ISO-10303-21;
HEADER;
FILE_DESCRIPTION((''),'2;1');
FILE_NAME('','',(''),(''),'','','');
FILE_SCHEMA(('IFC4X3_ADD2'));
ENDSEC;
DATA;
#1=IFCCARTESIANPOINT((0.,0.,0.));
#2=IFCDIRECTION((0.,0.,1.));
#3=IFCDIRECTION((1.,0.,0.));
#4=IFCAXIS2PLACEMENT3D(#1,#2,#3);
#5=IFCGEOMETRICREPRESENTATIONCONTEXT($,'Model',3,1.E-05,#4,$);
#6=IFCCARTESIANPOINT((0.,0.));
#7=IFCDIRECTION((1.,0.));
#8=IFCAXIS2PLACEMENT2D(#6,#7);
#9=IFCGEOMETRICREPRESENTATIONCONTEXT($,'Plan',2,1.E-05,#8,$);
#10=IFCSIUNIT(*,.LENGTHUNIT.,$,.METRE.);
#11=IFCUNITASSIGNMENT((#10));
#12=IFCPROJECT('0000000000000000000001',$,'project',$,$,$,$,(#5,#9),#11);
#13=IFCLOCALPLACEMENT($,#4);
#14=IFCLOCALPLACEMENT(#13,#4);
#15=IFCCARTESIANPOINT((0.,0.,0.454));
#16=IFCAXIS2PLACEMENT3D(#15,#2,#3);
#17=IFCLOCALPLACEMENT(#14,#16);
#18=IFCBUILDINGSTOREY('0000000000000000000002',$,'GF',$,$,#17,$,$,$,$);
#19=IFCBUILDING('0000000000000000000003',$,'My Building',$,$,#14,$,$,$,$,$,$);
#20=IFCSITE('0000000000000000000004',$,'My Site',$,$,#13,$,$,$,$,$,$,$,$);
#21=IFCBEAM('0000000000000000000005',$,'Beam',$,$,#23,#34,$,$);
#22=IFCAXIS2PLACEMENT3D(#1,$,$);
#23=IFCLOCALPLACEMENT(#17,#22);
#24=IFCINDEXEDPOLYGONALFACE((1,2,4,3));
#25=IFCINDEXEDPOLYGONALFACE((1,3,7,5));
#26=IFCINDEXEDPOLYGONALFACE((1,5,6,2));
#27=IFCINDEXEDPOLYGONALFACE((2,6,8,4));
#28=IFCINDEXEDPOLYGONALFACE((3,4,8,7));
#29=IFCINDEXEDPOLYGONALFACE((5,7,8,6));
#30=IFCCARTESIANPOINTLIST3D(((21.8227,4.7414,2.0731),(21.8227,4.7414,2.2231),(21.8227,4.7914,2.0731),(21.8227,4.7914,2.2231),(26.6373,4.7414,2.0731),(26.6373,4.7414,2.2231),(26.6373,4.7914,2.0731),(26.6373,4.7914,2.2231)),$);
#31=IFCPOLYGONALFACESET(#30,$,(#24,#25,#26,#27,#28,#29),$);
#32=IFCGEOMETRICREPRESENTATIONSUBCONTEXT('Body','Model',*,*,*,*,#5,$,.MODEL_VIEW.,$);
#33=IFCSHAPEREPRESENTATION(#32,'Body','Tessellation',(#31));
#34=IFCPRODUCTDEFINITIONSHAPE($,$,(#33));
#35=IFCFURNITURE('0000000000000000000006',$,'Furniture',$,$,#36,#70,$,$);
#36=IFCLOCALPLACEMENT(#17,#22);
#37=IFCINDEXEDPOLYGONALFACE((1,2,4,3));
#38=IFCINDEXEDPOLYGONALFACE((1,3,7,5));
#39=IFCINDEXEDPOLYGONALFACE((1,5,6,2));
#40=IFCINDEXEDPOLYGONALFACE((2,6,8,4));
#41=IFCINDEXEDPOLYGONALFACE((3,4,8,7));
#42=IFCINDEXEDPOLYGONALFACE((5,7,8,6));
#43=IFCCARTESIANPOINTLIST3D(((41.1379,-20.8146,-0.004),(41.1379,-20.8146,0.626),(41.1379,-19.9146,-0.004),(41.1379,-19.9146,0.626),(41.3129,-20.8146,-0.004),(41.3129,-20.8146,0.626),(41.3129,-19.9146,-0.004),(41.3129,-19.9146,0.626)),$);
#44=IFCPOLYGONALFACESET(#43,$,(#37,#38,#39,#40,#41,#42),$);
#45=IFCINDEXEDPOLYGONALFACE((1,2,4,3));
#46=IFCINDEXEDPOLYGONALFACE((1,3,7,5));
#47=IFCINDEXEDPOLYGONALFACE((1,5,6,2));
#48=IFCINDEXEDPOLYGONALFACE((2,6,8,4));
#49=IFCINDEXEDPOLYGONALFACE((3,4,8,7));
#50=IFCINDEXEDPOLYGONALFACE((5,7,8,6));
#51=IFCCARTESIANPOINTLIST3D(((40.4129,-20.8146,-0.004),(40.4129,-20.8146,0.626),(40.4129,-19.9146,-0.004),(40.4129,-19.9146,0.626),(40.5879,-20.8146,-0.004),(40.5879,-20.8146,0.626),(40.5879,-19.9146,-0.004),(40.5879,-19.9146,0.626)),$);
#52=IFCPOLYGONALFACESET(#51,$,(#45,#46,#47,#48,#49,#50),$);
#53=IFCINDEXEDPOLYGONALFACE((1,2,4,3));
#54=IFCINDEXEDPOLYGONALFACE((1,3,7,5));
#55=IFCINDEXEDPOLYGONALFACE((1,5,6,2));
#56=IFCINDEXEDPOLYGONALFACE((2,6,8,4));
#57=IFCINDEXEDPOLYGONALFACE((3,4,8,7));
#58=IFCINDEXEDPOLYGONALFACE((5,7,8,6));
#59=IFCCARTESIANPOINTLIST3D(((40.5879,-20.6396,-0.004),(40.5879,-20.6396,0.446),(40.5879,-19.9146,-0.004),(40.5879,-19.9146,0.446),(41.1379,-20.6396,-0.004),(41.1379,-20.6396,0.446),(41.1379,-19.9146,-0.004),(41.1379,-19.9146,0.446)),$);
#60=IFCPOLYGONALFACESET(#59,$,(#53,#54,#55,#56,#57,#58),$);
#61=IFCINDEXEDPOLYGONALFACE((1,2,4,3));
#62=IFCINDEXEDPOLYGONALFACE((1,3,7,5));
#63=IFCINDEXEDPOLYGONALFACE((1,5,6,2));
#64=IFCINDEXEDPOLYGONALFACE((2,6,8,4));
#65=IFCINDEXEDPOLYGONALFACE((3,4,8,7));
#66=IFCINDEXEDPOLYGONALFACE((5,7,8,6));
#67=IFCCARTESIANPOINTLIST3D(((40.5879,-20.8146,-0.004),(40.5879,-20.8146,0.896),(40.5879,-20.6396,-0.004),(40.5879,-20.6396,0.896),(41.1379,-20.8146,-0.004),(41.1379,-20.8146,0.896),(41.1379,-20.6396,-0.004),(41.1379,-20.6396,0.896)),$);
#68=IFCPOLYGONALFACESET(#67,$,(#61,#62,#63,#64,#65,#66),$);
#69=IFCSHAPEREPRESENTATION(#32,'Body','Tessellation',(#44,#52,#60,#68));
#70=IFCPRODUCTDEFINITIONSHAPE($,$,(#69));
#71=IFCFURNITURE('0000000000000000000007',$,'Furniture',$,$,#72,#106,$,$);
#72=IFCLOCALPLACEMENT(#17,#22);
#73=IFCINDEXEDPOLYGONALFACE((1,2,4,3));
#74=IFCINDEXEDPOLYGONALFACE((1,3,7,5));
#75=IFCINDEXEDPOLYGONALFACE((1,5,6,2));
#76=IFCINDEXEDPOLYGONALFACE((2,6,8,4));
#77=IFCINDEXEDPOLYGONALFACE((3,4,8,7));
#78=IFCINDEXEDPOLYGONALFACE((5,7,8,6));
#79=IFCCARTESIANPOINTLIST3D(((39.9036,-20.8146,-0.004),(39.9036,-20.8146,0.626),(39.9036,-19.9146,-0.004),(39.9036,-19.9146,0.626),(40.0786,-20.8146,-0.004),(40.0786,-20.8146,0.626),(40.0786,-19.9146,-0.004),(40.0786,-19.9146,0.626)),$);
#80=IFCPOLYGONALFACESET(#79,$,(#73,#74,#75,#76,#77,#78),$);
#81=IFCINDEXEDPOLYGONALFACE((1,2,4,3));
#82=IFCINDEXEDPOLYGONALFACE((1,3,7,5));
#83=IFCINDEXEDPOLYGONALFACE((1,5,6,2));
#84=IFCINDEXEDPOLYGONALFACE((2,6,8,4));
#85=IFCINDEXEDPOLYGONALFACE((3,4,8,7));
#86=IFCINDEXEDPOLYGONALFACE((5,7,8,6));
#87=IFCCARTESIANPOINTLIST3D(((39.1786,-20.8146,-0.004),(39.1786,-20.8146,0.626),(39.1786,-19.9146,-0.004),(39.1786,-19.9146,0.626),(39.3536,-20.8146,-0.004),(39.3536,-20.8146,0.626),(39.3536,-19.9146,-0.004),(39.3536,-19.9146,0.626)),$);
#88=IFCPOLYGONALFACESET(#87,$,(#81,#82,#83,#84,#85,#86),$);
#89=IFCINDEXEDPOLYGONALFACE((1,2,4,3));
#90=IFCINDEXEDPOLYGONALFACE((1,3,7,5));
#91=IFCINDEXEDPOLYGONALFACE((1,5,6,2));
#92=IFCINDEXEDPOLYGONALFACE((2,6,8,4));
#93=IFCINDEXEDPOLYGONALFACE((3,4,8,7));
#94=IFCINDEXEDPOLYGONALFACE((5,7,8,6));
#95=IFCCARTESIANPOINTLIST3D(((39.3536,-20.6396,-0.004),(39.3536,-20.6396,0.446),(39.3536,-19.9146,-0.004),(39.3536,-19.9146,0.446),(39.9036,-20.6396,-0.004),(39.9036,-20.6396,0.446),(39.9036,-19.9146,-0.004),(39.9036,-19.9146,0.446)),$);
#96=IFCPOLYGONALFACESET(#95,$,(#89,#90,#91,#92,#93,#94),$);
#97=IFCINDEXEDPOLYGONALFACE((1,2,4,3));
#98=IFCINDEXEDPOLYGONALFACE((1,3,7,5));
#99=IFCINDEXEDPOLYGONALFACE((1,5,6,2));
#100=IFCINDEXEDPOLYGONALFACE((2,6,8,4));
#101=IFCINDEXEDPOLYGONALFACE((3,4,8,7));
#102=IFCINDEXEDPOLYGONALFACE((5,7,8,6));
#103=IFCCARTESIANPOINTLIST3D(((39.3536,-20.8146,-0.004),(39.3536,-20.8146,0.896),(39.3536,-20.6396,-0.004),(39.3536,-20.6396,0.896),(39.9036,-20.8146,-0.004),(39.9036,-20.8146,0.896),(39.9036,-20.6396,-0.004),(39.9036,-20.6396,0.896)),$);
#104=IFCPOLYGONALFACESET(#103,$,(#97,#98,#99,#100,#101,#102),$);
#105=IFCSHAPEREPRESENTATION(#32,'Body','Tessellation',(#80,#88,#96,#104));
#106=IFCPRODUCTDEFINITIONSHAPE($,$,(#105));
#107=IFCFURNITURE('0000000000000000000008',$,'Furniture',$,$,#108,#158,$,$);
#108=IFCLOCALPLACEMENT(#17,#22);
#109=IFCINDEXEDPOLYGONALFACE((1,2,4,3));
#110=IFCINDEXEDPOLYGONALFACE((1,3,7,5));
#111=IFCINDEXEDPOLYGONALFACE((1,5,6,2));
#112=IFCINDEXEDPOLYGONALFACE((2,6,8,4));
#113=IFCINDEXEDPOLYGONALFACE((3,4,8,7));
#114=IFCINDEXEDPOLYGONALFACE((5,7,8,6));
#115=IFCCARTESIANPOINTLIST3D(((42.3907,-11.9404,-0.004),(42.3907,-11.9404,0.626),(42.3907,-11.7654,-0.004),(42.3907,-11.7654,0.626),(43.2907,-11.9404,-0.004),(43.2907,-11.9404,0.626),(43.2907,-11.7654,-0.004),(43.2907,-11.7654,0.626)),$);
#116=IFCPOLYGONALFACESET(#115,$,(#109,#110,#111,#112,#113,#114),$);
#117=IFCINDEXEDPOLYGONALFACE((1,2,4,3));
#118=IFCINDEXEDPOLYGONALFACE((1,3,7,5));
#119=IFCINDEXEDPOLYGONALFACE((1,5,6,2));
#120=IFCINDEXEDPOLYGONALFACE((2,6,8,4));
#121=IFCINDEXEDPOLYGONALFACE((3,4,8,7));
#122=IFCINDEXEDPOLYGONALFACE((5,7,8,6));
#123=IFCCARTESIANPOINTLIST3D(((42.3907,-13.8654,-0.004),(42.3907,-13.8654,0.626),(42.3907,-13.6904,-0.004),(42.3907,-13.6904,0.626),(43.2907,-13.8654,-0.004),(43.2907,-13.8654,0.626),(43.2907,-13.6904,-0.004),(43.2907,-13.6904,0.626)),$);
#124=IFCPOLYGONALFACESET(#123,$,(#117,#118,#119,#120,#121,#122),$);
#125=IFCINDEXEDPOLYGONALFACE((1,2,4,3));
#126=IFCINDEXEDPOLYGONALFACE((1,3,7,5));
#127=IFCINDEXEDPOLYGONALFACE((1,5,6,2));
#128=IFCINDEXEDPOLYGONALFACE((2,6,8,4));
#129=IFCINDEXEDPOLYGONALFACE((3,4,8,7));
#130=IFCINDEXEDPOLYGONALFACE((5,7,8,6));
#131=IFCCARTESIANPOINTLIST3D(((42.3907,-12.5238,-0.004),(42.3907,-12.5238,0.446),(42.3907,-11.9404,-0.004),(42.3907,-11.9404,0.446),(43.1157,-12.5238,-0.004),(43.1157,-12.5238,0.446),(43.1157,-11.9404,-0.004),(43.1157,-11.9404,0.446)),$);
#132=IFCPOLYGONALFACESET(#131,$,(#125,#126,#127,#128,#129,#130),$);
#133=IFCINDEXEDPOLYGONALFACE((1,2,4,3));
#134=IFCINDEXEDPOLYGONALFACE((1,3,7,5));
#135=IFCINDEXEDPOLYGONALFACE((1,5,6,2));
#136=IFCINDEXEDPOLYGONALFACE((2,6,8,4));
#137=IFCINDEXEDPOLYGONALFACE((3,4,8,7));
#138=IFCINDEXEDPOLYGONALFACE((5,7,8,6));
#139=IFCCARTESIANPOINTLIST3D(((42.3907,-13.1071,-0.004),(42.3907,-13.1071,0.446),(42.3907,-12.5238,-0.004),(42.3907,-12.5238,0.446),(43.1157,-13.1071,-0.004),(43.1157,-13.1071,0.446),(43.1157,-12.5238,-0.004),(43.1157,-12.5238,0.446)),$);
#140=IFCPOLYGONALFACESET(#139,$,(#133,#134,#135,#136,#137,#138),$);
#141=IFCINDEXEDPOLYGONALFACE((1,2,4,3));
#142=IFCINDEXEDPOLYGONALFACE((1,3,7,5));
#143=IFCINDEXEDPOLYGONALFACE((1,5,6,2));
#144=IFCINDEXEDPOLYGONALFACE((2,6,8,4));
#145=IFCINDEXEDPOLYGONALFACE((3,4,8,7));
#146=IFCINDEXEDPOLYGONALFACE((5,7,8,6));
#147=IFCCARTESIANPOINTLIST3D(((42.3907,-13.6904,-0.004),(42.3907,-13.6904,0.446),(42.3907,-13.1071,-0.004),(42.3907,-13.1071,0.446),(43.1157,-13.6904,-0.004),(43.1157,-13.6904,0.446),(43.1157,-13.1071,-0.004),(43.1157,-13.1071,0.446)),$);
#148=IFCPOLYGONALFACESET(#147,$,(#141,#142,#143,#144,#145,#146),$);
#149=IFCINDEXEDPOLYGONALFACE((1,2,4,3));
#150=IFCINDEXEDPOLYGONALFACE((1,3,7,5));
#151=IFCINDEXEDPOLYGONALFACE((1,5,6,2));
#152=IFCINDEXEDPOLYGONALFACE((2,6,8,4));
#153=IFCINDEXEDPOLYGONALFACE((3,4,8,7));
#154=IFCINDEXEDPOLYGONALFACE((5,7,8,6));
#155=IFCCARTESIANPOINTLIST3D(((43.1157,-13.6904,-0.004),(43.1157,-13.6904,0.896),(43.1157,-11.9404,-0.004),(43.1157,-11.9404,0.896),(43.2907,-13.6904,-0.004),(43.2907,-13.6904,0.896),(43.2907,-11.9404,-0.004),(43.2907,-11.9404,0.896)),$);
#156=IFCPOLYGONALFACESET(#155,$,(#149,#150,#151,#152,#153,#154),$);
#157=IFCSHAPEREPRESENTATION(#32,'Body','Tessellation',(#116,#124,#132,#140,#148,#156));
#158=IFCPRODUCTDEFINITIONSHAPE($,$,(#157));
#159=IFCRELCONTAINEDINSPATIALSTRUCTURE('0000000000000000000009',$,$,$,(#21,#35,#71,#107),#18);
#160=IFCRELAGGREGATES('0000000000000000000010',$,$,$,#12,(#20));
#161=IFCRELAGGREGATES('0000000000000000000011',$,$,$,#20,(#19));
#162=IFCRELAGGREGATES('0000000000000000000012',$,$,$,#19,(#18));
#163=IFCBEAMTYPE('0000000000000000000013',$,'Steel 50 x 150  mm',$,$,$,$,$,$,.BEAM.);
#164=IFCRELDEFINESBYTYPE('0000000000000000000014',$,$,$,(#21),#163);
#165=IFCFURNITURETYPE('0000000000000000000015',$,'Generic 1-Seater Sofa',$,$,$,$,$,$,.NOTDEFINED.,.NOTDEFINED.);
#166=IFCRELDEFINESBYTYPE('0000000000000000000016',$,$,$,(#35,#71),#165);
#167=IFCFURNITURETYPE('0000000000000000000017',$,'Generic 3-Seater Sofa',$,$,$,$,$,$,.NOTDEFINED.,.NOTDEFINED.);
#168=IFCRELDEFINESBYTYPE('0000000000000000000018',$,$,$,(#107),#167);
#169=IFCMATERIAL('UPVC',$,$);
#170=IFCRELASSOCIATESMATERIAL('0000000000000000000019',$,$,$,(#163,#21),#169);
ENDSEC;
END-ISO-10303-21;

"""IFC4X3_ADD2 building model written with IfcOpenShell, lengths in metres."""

from ifc_helpers import new_model, entity, si_unit, frame, origin_with_axes, origin_2d_with_axis, place, context, subcontext, project, spatial, line, indexed_curve, rectangle, outline, extrude, shape, source, transform, mapped, material, material_profile, profile_set, profile_usage, type_object, type_shapes, element, save


model = new_model("IFC4X3_ADD2")

# Units and contexts
model_context = context("Model", 3, precision=1e-05, world=origin_with_axes())
plan_context = context("Plan", 2, precision=1e-05, world=origin_2d_with_axis())
body_context_1 = subcontext(model_context, "Body", "Model", "MODEL_VIEW")
body_context_2 = subcontext(plan_context, "Body", "Plan", "PLAN_VIEW")
ifc_project = project(units=[si_unit("LENGTHUNIT", "METRE")], contexts=[model_context, plan_context])

# Site, building, storey
site_placement = place(None, origin_with_axes())
site = spatial("IfcSite", under=ifc_project, at=site_placement, Name="My Site")
building_placement = place(site_placement, origin_with_axes())
building = spatial("IfcBuilding", under=site, at=building_placement, Name="My Building")
storey_placement = place(building_placement, frame((0.0, 0.0, 0.454), z_axis=(0.0, 0.0, 1.0), x_axis=(1.0, 0.0, 0.0)))
storey = spatial("IfcBuildingStorey", under=building, at=storey_placement, Name="GF")

# Beam
ifc_material = material(Name="UPVC")
ifc_material_profile = material_profile(ifc_material, rectangle(XDim=0.05, YDim=0.15))
ifc_profile_set = profile_set([ifc_material_profile])
beam_type = type_object("IfcBeamType", Name="Steel 50 x 150  mm", PredefinedType="BEAM", material=ifc_profile_set)
ifc_profile_usage_1 = profile_usage(ifc_profile_set)
beam_1_placement = place(storey_placement, frame((21.8227, 4.7664, 2.1481), z_axis=(1.0, 0.0, 0.0), x_axis=(0.0, 1.0, 0.0)))
element("IfcBeam", 1, at=beam_1_placement, inside=storey, type_object=beam_type, material=ifc_profile_usage_1, Name="Beam", context=body_context_1, shape_type="SweptSolid", body=[
    extrude(rectangle(XDim=0.05, YDim=0.15), origin_with_axes(), (0.0, 0.0, 1.0), 4.8146),
])

# Furniture
furniture_type_1 = type_object("IfcFurnitureType", Name="Generic 1-Seater Sofa", AssemblyPlace="NOTDEFINED", PredefinedType="NOTDEFINED")
shared_shape_1 = source(origin_with_axes(), body_context_1, "Body", "SweptSolid", [
    extrude(outline(indexed_curve([(0.0, 0.0), (0.175, 0.0), (0.175, 0.9), (0.0, 0.9)], segments=[line(4, 1), line(1, 2), line(2, 3), line(3, 4)], self_intersect=False)), frame((-0.45, -0.9, 0.0), z_axis=(0.0, 0.0, 1.0), x_axis=(1.0, 0.0, 0.0)), (0.0, 0.0, 1.0), 0.63),
    extrude(outline(indexed_curve([(0.0, 0.0), (0.175, 0.0), (0.175, 0.9), (0.0, 0.9)], segments=[line(1, 2, 3, 4, 1)])), frame((0.275, -0.9, 0.0), z_axis=(0.0, 0.0, 1.0), x_axis=(1.0, 0.0, 0.0)), (0.0, 0.0, 1.0), 0.63),
    extrude(outline(indexed_curve([(0.175, 0.0), (0.725, 0.0), (0.725, 0.725), (0.175, 0.725)], segments=[line(1, 2, 3, 4, 1)])), frame((-0.45, -0.9, 0.0), z_axis=(0.0, 0.0, 1.0), x_axis=(1.0, 0.0, 0.0)), (0.0, 0.0, 1.0), 0.45),
    extrude(outline(indexed_curve([(0.175, 0.725), (0.725, 0.725), (0.725, 0.9), (0.175, 0.9)], segments=[line(1, 2, 3, 4, 1)])), frame((-0.45, -0.9, 0.0), z_axis=(0.0, 0.0, 1.0), x_axis=(1.0, 0.0, 0.0)), (0.0, 0.0, 1.0), 0.9),
])
shared_shape_2 = source(origin_with_axes(), body_context_2, "Body", "Annotation2D", [
    entity("IfcGeometricCurveSet", [entity("IfcIndexedPolyCurve", entity("IfcCartesianPointList2D", [[0.275, -0.175], [0.275, -0.9], [0.45, -0.9], [0.45, 0.0], [0.275, 0.0], [0.275, -0.9], [-0.275, -0.9], [-0.275, 0.0], [-0.275, -0.175], [0.275, -0.175], [0.275, 0.0], [-0.275, 0.0], [-0.45, 0.0], [-0.45, -0.9], [-0.275, -0.9], [-0.275, -0.175]]))]),
])
type_shapes(furniture_type_1, [shared_shape_1, shared_shape_2])
for number, where, z_axis, x_axis, name in (
    (2, (40.8629, -20.8146, -0.004), (0.0, 0.0, 1.0), (-1.0, 0.0, 0.0), "Furniture"),
    (3, (39.6286, -20.8146, -0.004), (0.0, 0.0, 1.0), (-1.0, 0.0, 0.0), "Furniture"),
):
    element("IfcFurniture", number, at=place(storey_placement, frame(where, z_axis=z_axis, x_axis=x_axis)), inside=storey, type_object=furniture_type_1, Name=name, shapes=[
        shape(body_context_1, "Body", "MappedRepresentation", [mapped(shared_shape_1, transform((0.0, 0.0, 0.0), x_axis=(1.0, 0.0, 0.0), y_axis=(0.0, 1.0, 0.0), z_axis=(0.0, 0.0, 1.0), scale=1.0))]),
        shape(body_context_2, "Body", "MappedRepresentation", [mapped(shared_shape_2, transform((0.0, 0.0, 0.0), x_axis=(1.0, 0.0, 0.0), y_axis=(0.0, 1.0, 0.0), z_axis=(0.0, 0.0, 1.0), scale=1.0))]),
    ])
furniture_type_2 = type_object("IfcFurnitureType", Name="Generic 3-Seater Sofa", AssemblyPlace="NOTDEFINED", PredefinedType="NOTDEFINED")
shared_shape_3 = source(origin_with_axes(), body_context_1, "Body", "SweptSolid", [
    extrude(outline(indexed_curve([(0.0, 0.0), (0.175, 0.0), (0.175, 0.9), (0.0, 0.9)], segments=[line(4, 1), line(1, 2), line(2, 3), line(3, 4)], self_intersect=False)), frame((-1.05, -0.9, 0.0), z_axis=(0.0, 0.0, 1.0), x_axis=(1.0, 0.0, 0.0)), (0.0, 0.0, 1.0), 0.63),
    extrude(outline(indexed_curve([(0.0, 0.0), (0.175, 0.0), (0.175, 0.9), (0.0, 0.9)], segments=[line(1, 2, 3, 4, 1)])), frame((0.875, -0.9, 0.0), z_axis=(0.0, 0.0, 1.0), x_axis=(1.0, 0.0, 0.0)), (0.0, 0.0, 1.0), 0.63),
    extrude(outline(indexed_curve([(0.175, 0.0), (0.7583, 0.0), (0.7583, 0.725), (0.175, 0.725)], segments=[line(1, 2, 3, 4, 1)])), frame((-1.05, -0.9, 0.0), z_axis=(0.0, 0.0, 1.0), x_axis=(1.0, 0.0, 0.0)), (0.0, 0.0, 1.0), 0.45),
    extrude(outline(indexed_curve([(0.7583, 0.0), (1.3417, 0.0), (1.3417, 0.725), (0.7583, 0.725)], segments=[line(1, 2, 3, 4, 1)])), frame((-1.05, -0.9, 0.0), z_axis=(0.0, 0.0, 1.0), x_axis=(1.0, 0.0, 0.0)), (0.0, 0.0, 1.0), 0.45),
    extrude(outline(indexed_curve([(1.3417, 0.0), (1.925, 0.0), (1.925, 0.725), (1.3417, 0.725)], segments=[line(1, 2, 3, 4, 1)])), frame((-1.05, -0.9, 0.0), z_axis=(0.0, 0.0, 1.0), x_axis=(1.0, 0.0, 0.0)), (0.0, 0.0, 1.0), 0.45),
    extrude(outline(indexed_curve([(0.175, 0.725), (1.925, 0.725), (1.925, 0.9), (0.175, 0.9)], segments=[line(1, 2, 3, 4, 1)])), frame((-1.05, -0.9, 0.0), z_axis=(0.0, 0.0, 1.0), x_axis=(1.0, 0.0, 0.0)), (0.0, 0.0, 1.0), 0.9),
])
shared_shape_4 = source(origin_with_axes(), body_context_2, "Body", "Annotation2D", [
    entity("IfcGeometricCurveSet", [entity("IfcIndexedPolyCurve", entity("IfcCartesianPointList2D", [[0.2917, -0.175], [0.2917, -0.9], [0.875, -0.9], [0.875, -0.175], [-0.875, -0.175], [-0.875, 0.0], [0.875, 0.0], [1.05, 0.0], [1.05, -0.9], [0.875, -0.9], [0.875, 0.0], [0.875, -0.175], [0.2917, -0.175], [-0.2917, -0.175], [-0.2917, -0.9], [-0.875, -0.9], [-0.875, 0.0], [-1.05, 0.0], [-1.05, -0.9], [-0.875, -0.9], [-0.875, -0.175], [-0.2917, -0.175]])), entity("IfcIndexedPolyCurve", entity("IfcCartesianPointList2D", [[0.2917, -0.9], [-0.2917, -0.9]]))]),
])
type_shapes(furniture_type_2, [shared_shape_3, shared_shape_4])
furniture_placement = place(storey_placement, frame((43.2907, -12.8154, -0.004), z_axis=(0.0, 0.0, 1.0), x_axis=(0.0, -1.0, 0.0)))
element("IfcFurniture", 4, at=furniture_placement, inside=storey, type_object=furniture_type_2, Name="Furniture", shapes=[
    shape(body_context_1, "Body", "MappedRepresentation", [mapped(shared_shape_3, transform((0.0, 0.0, 0.0), x_axis=(1.0, 0.0, 0.0), y_axis=(0.0, 1.0, 0.0), z_axis=(0.0, 0.0, 1.0), scale=1.0))]),
    shape(body_context_2, "Body", "MappedRepresentation", [mapped(shared_shape_4, transform((0.0, 0.0, 0.0), x_axis=(1.0, 0.0, 0.0), y_axis=(0.0, 1.0, 0.0), z_axis=(0.0, 0.0, 1.0), scale=1.0))]),
])

save(model, "model.ifc")
